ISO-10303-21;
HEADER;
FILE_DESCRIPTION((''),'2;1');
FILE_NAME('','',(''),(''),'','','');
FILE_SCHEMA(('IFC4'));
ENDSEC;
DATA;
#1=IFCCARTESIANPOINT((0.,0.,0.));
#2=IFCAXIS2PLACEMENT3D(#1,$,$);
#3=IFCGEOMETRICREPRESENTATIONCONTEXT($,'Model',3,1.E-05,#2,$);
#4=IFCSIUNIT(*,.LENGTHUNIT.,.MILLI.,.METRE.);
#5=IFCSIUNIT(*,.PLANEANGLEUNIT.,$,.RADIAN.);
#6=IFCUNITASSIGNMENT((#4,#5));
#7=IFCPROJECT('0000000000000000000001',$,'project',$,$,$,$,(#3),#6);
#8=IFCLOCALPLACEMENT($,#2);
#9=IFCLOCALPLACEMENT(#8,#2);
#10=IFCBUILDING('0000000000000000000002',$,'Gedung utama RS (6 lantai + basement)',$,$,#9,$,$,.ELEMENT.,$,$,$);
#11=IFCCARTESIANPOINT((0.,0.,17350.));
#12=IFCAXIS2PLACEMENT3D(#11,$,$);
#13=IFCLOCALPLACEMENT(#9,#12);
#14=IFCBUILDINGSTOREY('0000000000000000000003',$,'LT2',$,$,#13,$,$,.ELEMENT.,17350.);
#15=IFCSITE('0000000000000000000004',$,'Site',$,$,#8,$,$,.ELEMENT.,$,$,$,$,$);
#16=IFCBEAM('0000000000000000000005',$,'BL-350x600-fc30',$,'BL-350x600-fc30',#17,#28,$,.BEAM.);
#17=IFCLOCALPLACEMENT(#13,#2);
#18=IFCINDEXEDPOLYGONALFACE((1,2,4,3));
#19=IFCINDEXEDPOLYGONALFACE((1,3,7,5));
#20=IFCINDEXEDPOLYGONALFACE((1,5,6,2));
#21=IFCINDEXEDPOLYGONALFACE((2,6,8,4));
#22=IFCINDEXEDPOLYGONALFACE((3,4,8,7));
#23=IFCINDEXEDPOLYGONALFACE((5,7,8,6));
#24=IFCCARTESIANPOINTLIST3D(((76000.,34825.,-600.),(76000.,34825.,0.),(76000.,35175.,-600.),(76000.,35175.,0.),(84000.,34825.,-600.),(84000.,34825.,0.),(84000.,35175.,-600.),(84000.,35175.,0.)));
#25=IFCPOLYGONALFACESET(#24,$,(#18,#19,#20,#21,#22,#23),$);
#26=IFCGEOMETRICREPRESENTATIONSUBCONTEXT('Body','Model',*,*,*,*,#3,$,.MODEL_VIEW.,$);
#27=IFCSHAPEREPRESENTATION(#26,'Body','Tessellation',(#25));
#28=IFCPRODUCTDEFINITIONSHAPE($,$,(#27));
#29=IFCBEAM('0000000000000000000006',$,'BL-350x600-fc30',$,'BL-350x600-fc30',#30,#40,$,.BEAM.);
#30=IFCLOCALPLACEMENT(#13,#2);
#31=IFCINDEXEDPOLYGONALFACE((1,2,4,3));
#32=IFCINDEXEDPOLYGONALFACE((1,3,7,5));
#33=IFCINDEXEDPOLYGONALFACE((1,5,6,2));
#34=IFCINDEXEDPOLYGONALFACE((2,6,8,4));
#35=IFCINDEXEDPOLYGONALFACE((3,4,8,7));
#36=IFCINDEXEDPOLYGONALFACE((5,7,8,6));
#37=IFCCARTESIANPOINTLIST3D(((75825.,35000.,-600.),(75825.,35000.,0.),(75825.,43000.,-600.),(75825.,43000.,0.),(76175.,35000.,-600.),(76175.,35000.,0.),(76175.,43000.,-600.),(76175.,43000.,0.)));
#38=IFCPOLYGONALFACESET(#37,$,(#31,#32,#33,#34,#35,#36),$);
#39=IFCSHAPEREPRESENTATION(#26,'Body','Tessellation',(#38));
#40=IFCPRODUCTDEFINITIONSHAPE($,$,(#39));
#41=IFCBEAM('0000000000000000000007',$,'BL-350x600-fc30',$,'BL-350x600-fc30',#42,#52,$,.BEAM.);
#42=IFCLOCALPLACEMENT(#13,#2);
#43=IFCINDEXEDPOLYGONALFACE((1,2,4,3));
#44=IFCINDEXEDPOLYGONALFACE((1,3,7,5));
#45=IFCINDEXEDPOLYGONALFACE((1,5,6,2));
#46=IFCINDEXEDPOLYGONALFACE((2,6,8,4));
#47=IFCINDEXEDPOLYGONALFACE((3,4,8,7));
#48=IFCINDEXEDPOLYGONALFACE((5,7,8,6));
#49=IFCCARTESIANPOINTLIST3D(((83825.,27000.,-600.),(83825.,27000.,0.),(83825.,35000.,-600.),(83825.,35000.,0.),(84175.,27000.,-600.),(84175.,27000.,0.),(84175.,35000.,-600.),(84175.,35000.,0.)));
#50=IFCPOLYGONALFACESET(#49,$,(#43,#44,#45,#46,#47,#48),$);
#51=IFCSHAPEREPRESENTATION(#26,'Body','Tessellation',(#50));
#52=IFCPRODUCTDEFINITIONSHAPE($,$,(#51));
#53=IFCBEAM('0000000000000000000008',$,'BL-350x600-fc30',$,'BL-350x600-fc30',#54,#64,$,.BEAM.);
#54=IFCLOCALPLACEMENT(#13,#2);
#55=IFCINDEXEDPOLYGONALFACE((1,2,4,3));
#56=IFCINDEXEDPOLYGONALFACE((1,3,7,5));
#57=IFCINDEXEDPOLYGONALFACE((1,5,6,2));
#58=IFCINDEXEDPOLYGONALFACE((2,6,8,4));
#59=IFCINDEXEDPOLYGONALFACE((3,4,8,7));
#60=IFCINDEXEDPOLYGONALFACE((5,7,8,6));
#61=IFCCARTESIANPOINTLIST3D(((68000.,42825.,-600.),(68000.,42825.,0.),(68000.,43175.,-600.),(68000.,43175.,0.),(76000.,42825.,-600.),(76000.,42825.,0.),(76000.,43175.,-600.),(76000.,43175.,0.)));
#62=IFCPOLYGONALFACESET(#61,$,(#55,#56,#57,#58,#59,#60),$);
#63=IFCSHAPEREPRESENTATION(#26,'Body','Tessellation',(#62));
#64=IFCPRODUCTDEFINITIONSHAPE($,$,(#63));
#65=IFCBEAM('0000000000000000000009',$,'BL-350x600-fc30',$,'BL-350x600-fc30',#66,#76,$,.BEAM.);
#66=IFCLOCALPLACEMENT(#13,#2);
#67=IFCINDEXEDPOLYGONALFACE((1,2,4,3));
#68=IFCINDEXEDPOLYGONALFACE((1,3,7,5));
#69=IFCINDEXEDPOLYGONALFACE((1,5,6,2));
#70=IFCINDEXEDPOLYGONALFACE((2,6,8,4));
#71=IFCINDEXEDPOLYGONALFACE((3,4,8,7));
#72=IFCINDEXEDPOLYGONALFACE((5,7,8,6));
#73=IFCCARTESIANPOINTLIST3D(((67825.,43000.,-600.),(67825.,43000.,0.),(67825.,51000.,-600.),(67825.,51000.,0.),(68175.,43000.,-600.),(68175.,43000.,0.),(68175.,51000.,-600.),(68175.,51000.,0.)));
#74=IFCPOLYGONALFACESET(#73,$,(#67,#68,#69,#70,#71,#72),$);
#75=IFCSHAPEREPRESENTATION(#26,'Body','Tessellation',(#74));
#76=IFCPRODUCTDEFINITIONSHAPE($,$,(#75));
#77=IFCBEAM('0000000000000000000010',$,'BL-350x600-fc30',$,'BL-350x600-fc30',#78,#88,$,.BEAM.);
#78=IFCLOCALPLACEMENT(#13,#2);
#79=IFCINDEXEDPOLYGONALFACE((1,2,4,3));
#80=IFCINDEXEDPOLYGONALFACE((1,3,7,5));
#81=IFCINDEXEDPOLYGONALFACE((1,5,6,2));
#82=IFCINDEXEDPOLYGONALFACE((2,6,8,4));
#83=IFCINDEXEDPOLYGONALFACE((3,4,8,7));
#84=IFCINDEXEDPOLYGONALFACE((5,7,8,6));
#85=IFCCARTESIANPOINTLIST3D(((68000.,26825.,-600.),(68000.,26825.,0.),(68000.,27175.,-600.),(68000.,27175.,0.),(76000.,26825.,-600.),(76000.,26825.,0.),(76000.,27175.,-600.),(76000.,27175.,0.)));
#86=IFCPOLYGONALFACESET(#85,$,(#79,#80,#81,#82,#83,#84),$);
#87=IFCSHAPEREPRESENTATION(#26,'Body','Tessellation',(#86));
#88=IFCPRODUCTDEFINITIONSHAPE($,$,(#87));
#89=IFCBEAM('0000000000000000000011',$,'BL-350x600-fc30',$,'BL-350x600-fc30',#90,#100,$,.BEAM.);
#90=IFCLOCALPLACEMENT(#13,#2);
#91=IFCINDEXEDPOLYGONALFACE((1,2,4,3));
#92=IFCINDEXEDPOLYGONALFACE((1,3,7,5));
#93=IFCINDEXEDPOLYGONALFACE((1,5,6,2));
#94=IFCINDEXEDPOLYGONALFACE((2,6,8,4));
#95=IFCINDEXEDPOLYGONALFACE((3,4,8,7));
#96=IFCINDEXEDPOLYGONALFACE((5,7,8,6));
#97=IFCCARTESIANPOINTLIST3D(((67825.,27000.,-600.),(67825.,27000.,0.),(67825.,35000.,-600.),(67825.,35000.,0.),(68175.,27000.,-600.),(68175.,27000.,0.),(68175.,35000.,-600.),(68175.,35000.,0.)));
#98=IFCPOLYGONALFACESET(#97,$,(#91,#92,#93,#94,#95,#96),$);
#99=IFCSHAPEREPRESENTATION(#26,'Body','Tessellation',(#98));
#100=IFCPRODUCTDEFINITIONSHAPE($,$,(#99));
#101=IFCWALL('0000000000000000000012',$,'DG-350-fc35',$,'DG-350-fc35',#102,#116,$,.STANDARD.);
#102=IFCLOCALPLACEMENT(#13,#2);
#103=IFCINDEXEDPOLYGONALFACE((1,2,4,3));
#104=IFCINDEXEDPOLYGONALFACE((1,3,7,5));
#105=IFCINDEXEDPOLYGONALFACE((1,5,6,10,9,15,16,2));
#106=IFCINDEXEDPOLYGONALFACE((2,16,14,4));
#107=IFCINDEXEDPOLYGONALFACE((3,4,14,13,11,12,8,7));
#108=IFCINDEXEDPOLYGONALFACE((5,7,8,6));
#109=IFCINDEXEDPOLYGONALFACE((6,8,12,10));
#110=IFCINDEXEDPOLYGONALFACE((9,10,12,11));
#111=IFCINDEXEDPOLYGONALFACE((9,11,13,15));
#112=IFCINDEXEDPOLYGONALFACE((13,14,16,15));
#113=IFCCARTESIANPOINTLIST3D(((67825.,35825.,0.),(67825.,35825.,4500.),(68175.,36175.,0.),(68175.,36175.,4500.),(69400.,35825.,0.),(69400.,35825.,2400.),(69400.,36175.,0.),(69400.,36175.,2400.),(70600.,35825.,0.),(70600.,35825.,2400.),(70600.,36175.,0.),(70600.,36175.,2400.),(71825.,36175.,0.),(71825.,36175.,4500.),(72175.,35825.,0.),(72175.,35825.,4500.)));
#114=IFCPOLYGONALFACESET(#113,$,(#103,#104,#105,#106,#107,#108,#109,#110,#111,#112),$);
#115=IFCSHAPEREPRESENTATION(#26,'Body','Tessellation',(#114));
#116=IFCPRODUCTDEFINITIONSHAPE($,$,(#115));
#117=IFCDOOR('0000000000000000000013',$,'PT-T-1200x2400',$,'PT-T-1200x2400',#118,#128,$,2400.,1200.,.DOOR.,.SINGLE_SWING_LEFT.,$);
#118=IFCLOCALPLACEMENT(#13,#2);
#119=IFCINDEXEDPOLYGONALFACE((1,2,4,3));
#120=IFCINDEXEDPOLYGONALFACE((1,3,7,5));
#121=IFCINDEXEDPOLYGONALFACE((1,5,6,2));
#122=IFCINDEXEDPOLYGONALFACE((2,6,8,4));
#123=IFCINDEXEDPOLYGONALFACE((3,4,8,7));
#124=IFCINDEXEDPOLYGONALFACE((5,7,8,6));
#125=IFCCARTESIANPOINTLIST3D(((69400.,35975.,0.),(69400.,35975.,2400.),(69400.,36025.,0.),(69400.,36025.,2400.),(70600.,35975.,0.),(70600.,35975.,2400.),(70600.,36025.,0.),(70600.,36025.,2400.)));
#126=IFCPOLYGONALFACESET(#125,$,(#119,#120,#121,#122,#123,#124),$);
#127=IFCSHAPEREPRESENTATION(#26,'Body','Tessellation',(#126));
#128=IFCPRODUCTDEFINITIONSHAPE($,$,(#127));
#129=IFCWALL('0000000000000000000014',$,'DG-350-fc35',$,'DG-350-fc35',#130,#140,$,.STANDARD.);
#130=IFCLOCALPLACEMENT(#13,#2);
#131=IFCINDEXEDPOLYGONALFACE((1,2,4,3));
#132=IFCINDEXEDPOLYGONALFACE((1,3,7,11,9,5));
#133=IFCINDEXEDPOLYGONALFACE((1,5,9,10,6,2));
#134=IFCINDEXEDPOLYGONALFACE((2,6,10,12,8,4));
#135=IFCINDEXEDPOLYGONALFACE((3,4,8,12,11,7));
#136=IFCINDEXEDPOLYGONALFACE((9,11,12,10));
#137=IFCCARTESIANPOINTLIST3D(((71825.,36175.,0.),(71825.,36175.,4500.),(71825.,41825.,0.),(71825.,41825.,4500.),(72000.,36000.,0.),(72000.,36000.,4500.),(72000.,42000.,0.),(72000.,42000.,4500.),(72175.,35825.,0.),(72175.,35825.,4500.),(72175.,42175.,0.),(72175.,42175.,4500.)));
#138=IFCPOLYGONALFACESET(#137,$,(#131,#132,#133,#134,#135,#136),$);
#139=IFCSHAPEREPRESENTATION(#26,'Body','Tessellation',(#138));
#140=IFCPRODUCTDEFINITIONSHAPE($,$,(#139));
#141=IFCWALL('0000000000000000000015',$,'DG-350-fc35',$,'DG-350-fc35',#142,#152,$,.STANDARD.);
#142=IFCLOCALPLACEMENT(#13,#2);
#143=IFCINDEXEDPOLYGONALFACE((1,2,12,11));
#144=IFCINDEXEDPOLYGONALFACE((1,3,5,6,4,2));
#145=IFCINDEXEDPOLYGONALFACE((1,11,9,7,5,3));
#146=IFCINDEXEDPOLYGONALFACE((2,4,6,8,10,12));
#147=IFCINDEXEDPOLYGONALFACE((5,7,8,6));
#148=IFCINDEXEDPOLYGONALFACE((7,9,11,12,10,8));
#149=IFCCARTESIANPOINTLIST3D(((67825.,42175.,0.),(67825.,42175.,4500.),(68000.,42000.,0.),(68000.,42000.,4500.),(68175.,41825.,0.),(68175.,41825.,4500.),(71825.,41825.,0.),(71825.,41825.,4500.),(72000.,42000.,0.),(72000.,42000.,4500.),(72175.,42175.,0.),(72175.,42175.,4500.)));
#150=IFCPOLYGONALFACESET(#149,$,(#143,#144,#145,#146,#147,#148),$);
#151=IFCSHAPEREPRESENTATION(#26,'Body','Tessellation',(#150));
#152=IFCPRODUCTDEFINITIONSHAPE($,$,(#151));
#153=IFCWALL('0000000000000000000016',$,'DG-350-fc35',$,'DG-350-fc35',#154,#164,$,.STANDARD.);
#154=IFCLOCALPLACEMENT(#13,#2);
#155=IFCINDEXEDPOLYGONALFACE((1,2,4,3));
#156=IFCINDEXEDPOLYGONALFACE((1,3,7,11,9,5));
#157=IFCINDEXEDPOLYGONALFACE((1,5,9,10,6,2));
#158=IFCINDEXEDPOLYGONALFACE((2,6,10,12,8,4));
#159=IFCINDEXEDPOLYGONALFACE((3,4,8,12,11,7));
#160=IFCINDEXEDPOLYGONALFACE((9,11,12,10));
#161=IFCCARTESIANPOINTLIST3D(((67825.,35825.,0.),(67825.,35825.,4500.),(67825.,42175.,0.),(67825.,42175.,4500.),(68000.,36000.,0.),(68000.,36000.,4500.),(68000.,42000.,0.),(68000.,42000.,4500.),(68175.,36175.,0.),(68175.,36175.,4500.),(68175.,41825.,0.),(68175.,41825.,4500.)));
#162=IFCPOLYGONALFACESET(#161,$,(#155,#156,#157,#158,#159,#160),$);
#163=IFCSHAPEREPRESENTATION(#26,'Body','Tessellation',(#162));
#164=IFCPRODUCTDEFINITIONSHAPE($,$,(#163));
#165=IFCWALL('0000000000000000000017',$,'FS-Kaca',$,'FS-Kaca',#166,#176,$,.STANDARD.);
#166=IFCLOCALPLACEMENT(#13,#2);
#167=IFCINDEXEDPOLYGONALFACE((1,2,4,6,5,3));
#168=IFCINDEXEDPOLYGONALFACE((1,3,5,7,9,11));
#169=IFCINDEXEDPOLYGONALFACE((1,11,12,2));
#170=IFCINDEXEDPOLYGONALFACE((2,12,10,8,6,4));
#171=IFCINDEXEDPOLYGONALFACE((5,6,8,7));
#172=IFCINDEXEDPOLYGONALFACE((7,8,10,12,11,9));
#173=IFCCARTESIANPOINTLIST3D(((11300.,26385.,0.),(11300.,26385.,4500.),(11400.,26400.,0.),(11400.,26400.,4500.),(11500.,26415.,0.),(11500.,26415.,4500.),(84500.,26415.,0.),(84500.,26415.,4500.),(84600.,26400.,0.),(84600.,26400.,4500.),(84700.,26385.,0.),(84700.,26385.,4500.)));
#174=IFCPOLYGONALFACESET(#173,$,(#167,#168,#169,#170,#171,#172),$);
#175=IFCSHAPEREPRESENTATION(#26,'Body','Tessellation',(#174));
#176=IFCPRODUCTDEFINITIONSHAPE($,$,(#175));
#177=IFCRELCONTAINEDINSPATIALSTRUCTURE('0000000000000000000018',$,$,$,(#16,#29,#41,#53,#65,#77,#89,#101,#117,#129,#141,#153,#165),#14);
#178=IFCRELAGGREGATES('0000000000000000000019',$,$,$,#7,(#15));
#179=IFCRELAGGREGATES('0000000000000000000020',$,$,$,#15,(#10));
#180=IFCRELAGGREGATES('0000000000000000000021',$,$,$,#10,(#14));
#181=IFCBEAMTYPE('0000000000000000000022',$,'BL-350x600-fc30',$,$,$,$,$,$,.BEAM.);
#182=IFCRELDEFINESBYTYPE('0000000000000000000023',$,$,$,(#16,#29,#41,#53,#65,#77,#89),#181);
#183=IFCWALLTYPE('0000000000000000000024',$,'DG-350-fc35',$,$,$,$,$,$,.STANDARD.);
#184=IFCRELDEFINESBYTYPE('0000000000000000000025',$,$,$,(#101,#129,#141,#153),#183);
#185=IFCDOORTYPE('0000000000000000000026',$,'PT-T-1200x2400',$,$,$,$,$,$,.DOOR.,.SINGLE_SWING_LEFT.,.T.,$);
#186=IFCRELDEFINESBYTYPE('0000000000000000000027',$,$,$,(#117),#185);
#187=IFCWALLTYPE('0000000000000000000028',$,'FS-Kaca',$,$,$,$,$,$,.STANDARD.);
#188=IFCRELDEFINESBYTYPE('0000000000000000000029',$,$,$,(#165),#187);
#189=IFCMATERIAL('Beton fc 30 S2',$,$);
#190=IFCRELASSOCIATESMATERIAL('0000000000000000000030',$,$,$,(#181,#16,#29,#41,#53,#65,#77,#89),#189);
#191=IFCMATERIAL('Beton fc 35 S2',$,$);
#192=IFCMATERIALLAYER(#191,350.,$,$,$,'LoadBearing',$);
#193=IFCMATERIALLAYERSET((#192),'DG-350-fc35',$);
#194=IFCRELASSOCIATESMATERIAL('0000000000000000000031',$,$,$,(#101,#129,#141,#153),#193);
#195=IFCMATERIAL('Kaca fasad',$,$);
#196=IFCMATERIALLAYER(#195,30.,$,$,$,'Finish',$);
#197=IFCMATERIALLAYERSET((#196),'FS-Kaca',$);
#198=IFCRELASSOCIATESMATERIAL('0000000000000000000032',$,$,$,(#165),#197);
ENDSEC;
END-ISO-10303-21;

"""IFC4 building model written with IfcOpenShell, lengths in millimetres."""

from ifc_helpers import new_model, si_unit, frame, frame_2d, origin, origin_2d, place, context, subcontext, project, spatial, polyline, rectangle, outline, extrude, material, layer, layer_set, layer_usage, material_profile, profile_set, profile_usage, type_object, element, fill, save


model = new_model("IFC4")

# Units and contexts
model_context = context("Model", 3, precision=1e-05, world=origin())
body_context = subcontext(model_context, "Body", "Model", "MODEL_VIEW")
ifc_project = project(units=[si_unit("LENGTHUNIT", "METRE", prefix="MILLI"), si_unit("PLANEANGLEUNIT", "RADIAN")], contexts=[model_context])

# Site, building, storey
site_placement = place(None, origin())
site = spatial("IfcSite", under=ifc_project, at=site_placement, Name="Site", CompositionType="ELEMENT")
building_placement = place(site_placement, origin())
building = spatial("IfcBuilding", under=site, at=building_placement, Name="Gedung utama RS (6 lantai + basement)", CompositionType="ELEMENT")
storey_placement = place(building_placement, frame((0.0, 0.0, 17350.0)))
storey = spatial("IfcBuildingStorey", under=building, at=storey_placement, Name="LT2", CompositionType="ELEMENT", Elevation=17350.0)

# Beams
ifc_material_1 = material(Name="Beton fc 30 S2")
ifc_material_profile_1 = material_profile(ifc_material_1, rectangle(XDim=350.0, YDim=600.0, at=origin_2d()), Name="BL-350x600-fc30")
ifc_profile_set_1 = profile_set([ifc_material_profile_1], Name="BL-350x600-fc30")
ifc_profile_usage_1 = profile_usage(ifc_profile_set_1, cardinal=8)
beam_type = type_object("IfcBeamType", Name="BL-350x600-fc30", PredefinedType="BEAM", material=ifc_profile_set_1)
beam_1_placement = place(storey_placement, frame((76000.0, 35000.0, -300.0)))
element("IfcBeam", 1, at=beam_1_placement, inside=storey, type_object=beam_type, material=ifc_profile_usage_1, Name="BL-350x600-fc30", ObjectType="BL-350x600-fc30", PredefinedType="BEAM", context=body_context, shape_type="SweptSolid", body=[
    extrude(rectangle(XDim=350.0, YDim=600.0, at=origin_2d()), frame((0.0, 0.0, 0.0), z_axis=(1.0, 0.0, 0.0), x_axis=(0.0, 1.0, 0.0)), (0.0, 0.0, 1.0), 8000.0),
])
for number, where, name in (
    (2, (76000.0, 35000.0, -300.0), "BL-350x600-fc30"),
    (3, (84000.0, 27000.0, -300.0), "BL-350x600-fc30"),
):
    element("IfcBeam", number, at=place(storey_placement, frame(where)), inside=storey, type_object=beam_type, material=ifc_profile_usage_1, Name=name, ObjectType="BL-350x600-fc30", PredefinedType="BEAM", context=body_context, shape_type="SweptSolid", body=[
        extrude(rectangle(XDim=350.0, YDim=600.0, at=origin_2d()), frame((0.0, 0.0, 0.0), z_axis=(0.0, 1.0, 0.0), x_axis=(-1.0, 0.0, 0.0)), (0.0, 0.0, 1.0), 8000.0),
    ])
beam_2_placement = place(storey_placement, frame((68000.0, 43000.0, -300.0)))
element("IfcBeam", 4, at=beam_2_placement, inside=storey, type_object=beam_type, material=ifc_profile_usage_1, Name="BL-350x600-fc30", ObjectType="BL-350x600-fc30", PredefinedType="BEAM", context=body_context, shape_type="SweptSolid", body=[
    extrude(rectangle(XDim=350.0, YDim=600.0, at=origin_2d()), frame((0.0, 0.0, 0.0), z_axis=(1.0, 0.0, 0.0), x_axis=(0.0, 1.0, 0.0)), (0.0, 0.0, 1.0), 8000.0),
])
beam_3_placement = place(storey_placement, frame((68000.0, 43000.0, -300.0)))
element("IfcBeam", 5, at=beam_3_placement, inside=storey, type_object=beam_type, material=ifc_profile_usage_1, Name="BL-350x600-fc30", ObjectType="BL-350x600-fc30", PredefinedType="BEAM", context=body_context, shape_type="SweptSolid", body=[
    extrude(rectangle(XDim=350.0, YDim=600.0, at=origin_2d()), frame((0.0, 0.0, 0.0), z_axis=(0.0, 1.0, 0.0), x_axis=(-1.0, 0.0, 0.0)), (0.0, 0.0, 1.0), 8000.0),
])
beam_4_placement = place(storey_placement, frame((68000.0, 27000.0, -300.0)))
element("IfcBeam", 6, at=beam_4_placement, inside=storey, type_object=beam_type, material=ifc_profile_usage_1, Name="BL-350x600-fc30", ObjectType="BL-350x600-fc30", PredefinedType="BEAM", context=body_context, shape_type="SweptSolid", body=[
    extrude(rectangle(XDim=350.0, YDim=600.0, at=origin_2d()), frame((0.0, 0.0, 0.0), z_axis=(1.0, 0.0, 0.0), x_axis=(0.0, 1.0, 0.0)), (0.0, 0.0, 1.0), 8000.0),
])
beam_5_placement = place(storey_placement, frame((68000.0, 27000.0, -300.0)))
element("IfcBeam", 7, at=beam_5_placement, inside=storey, type_object=beam_type, material=ifc_profile_usage_1, Name="BL-350x600-fc30", ObjectType="BL-350x600-fc30", PredefinedType="BEAM", context=body_context, shape_type="SweptSolid", body=[
    extrude(rectangle(XDim=350.0, YDim=600.0, at=origin_2d()), frame((0.0, 0.0, 0.0), z_axis=(0.0, 1.0, 0.0), x_axis=(-1.0, 0.0, 0.0)), (0.0, 0.0, 1.0), 8000.0),
])

# Wall, opening, door
ifc_material_2 = material(Name="Beton fc 35 S2")
ifc_layer_1 = layer(ifc_material_2, 350.0, Category="LoadBearing")
ifc_layer_set_1 = layer_set([ifc_layer_1], Name="DG-350-fc35")
ifc_layer_usage_1 = layer_usage(ifc_layer_set_1, "AXIS2", "NEGATIVE", 175.0)
wall_type_1 = type_object("IfcWallType", Name="DG-350-fc35", PredefinedType="STANDARD")
wall_1_placement = place(storey_placement, frame((68000.0, 36000.0, 0.0), z_axis=(0.0, 0.0, 1.0), x_axis=(1.0, 0.0, 0.0)))
wall_1 = element("IfcWall", 8, at=wall_1_placement, inside=storey, type_object=wall_type_1, material=ifc_layer_usage_1, Name="DG-350-fc35", ObjectType="DG-350-fc35", PredefinedType="STANDARD", context=body_context, shape_type="SweptSolid", body=[
    extrude(outline(polyline([(-175.0, -175.0), (0.0, 0.0), (175.0, 175.0), (3825.0, 175.0), (4000.0, 0.0), (4175.0, -175.0), (-175.0, -175.0)])), origin(), (0.0, 0.0, 1.0), 4500.0),
])
opening_placement = place(wall_1_placement, frame((1400.0, 0.0, 0.0), z_axis=(0.0, 0.0, 1.0), x_axis=(1.0, 0.0, 0.0)))
opening = element("IfcOpeningElement", 9, at=opening_placement, cuts=wall_1, PredefinedType="OPENING", context=body_context, shape_type="SweptSolid", body=[
    extrude(rectangle(XDim=1200.0, YDim=370.0, at=frame_2d((600.0, 0.0))), origin(), (0.0, 0.0, 1.0), 2400.0),
])
door_type = type_object("IfcDoorType", Name="PT-T-1200x2400", OperationType="SINGLE_SWING_LEFT", ParameterTakesPrecedence=True, PredefinedType="DOOR")
door_placement = place(opening_placement, origin())
door = element("IfcDoor", 10, at=door_placement, inside=storey, type_object=door_type, Name="PT-T-1200x2400", ObjectType="PT-T-1200x2400", OperationType="SINGLE_SWING_LEFT", OverallHeight=2400.0, OverallWidth=1200.0, PredefinedType="DOOR", context=body_context, shape_type="SweptSolid", body=[
    extrude(rectangle(XDim=1200.0, YDim=50.0, at=frame_2d((600.0, 0.0))), origin(), (0.0, 0.0, 1.0), 2400.0),
])
fill(opening, door)

# Walls
wall_2_placement = place(storey_placement, frame((72000.0, 36000.0, 0.0), z_axis=(0.0, 0.0, 1.0), x_axis=(0.0, 1.0, 0.0)))
element("IfcWall", 11, at=wall_2_placement, inside=storey, type_object=wall_type_1, material=ifc_layer_usage_1, Name="DG-350-fc35", ObjectType="DG-350-fc35", PredefinedType="STANDARD", context=body_context, shape_type="SweptSolid", body=[
    extrude(outline(polyline([(-175.0, -175.0), (0.0, 0.0), (175.0, 175.0), (5825.0, 175.0), (6000.0, 0.0), (6175.0, -175.0), (-175.0, -175.0)])), origin(), (0.0, 0.0, 1.0), 4500.0),
])
wall_3_placement = place(storey_placement, frame((72000.0, 42000.0, 0.0), z_axis=(0.0, 0.0, 1.0), x_axis=(-1.0, 0.0, 0.0)))
element("IfcWall", 12, at=wall_3_placement, inside=storey, type_object=wall_type_1, material=ifc_layer_usage_1, Name="DG-350-fc35", ObjectType="DG-350-fc35", PredefinedType="STANDARD", context=body_context, shape_type="SweptSolid", body=[
    extrude(outline(polyline([(-175.0, -175.0), (0.0, 0.0), (175.0, 175.0), (3825.0, 175.0), (4000.0, 0.0), (4175.0, -175.0), (-175.0, -175.0)])), origin(), (0.0, 0.0, 1.0), 4500.0),
])
wall_4_placement = place(storey_placement, frame((68000.0, 42000.0, 0.0), z_axis=(0.0, 0.0, 1.0), x_axis=(0.0, -1.0, 0.0)))
element("IfcWall", 13, at=wall_4_placement, inside=storey, type_object=wall_type_1, material=ifc_layer_usage_1, Name="DG-350-fc35", ObjectType="DG-350-fc35", PredefinedType="STANDARD", context=body_context, shape_type="SweptSolid", body=[
    extrude(outline(polyline([(-175.0, -175.0), (0.0, 0.0), (175.0, 175.0), (5825.0, 175.0), (6000.0, 0.0), (6175.0, -175.0), (-175.0, -175.0)])), origin(), (0.0, 0.0, 1.0), 4500.0),
])
ifc_material_3 = material(Name="Kaca fasad")
ifc_layer_2 = layer(ifc_material_3, 30.0, Category="Finish")
ifc_layer_set_2 = layer_set([ifc_layer_2], Name="FS-Kaca")
ifc_layer_usage_2 = layer_usage(ifc_layer_set_2, "AXIS2", "NEGATIVE", 15.0)
wall_type_2 = type_object("IfcWallType", Name="FS-Kaca", PredefinedType="STANDARD")
wall_5_placement = place(storey_placement, frame((84600.0, 26400.0, 0.0), z_axis=(0.0, 0.0, 1.0), x_axis=(-1.0, 0.0, 0.0)))
element("IfcWall", 14, at=wall_5_placement, inside=storey, type_object=wall_type_2, material=ifc_layer_usage_2, Name="FS-Kaca", ObjectType="FS-Kaca", PredefinedType="STANDARD", context=body_context, shape_type="SweptSolid", body=[
    extrude(outline(polyline([(100.0, -15.0), (0.0, 0.0), (-100.0, 15.0), (73300.0, 15.0), (73200.0, 0.0), (73100.0, -15.0), (100.0, -15.0)])), origin(), (0.0, 0.0, 1.0), 4500.0),
])

save(model, "model.ifc")
